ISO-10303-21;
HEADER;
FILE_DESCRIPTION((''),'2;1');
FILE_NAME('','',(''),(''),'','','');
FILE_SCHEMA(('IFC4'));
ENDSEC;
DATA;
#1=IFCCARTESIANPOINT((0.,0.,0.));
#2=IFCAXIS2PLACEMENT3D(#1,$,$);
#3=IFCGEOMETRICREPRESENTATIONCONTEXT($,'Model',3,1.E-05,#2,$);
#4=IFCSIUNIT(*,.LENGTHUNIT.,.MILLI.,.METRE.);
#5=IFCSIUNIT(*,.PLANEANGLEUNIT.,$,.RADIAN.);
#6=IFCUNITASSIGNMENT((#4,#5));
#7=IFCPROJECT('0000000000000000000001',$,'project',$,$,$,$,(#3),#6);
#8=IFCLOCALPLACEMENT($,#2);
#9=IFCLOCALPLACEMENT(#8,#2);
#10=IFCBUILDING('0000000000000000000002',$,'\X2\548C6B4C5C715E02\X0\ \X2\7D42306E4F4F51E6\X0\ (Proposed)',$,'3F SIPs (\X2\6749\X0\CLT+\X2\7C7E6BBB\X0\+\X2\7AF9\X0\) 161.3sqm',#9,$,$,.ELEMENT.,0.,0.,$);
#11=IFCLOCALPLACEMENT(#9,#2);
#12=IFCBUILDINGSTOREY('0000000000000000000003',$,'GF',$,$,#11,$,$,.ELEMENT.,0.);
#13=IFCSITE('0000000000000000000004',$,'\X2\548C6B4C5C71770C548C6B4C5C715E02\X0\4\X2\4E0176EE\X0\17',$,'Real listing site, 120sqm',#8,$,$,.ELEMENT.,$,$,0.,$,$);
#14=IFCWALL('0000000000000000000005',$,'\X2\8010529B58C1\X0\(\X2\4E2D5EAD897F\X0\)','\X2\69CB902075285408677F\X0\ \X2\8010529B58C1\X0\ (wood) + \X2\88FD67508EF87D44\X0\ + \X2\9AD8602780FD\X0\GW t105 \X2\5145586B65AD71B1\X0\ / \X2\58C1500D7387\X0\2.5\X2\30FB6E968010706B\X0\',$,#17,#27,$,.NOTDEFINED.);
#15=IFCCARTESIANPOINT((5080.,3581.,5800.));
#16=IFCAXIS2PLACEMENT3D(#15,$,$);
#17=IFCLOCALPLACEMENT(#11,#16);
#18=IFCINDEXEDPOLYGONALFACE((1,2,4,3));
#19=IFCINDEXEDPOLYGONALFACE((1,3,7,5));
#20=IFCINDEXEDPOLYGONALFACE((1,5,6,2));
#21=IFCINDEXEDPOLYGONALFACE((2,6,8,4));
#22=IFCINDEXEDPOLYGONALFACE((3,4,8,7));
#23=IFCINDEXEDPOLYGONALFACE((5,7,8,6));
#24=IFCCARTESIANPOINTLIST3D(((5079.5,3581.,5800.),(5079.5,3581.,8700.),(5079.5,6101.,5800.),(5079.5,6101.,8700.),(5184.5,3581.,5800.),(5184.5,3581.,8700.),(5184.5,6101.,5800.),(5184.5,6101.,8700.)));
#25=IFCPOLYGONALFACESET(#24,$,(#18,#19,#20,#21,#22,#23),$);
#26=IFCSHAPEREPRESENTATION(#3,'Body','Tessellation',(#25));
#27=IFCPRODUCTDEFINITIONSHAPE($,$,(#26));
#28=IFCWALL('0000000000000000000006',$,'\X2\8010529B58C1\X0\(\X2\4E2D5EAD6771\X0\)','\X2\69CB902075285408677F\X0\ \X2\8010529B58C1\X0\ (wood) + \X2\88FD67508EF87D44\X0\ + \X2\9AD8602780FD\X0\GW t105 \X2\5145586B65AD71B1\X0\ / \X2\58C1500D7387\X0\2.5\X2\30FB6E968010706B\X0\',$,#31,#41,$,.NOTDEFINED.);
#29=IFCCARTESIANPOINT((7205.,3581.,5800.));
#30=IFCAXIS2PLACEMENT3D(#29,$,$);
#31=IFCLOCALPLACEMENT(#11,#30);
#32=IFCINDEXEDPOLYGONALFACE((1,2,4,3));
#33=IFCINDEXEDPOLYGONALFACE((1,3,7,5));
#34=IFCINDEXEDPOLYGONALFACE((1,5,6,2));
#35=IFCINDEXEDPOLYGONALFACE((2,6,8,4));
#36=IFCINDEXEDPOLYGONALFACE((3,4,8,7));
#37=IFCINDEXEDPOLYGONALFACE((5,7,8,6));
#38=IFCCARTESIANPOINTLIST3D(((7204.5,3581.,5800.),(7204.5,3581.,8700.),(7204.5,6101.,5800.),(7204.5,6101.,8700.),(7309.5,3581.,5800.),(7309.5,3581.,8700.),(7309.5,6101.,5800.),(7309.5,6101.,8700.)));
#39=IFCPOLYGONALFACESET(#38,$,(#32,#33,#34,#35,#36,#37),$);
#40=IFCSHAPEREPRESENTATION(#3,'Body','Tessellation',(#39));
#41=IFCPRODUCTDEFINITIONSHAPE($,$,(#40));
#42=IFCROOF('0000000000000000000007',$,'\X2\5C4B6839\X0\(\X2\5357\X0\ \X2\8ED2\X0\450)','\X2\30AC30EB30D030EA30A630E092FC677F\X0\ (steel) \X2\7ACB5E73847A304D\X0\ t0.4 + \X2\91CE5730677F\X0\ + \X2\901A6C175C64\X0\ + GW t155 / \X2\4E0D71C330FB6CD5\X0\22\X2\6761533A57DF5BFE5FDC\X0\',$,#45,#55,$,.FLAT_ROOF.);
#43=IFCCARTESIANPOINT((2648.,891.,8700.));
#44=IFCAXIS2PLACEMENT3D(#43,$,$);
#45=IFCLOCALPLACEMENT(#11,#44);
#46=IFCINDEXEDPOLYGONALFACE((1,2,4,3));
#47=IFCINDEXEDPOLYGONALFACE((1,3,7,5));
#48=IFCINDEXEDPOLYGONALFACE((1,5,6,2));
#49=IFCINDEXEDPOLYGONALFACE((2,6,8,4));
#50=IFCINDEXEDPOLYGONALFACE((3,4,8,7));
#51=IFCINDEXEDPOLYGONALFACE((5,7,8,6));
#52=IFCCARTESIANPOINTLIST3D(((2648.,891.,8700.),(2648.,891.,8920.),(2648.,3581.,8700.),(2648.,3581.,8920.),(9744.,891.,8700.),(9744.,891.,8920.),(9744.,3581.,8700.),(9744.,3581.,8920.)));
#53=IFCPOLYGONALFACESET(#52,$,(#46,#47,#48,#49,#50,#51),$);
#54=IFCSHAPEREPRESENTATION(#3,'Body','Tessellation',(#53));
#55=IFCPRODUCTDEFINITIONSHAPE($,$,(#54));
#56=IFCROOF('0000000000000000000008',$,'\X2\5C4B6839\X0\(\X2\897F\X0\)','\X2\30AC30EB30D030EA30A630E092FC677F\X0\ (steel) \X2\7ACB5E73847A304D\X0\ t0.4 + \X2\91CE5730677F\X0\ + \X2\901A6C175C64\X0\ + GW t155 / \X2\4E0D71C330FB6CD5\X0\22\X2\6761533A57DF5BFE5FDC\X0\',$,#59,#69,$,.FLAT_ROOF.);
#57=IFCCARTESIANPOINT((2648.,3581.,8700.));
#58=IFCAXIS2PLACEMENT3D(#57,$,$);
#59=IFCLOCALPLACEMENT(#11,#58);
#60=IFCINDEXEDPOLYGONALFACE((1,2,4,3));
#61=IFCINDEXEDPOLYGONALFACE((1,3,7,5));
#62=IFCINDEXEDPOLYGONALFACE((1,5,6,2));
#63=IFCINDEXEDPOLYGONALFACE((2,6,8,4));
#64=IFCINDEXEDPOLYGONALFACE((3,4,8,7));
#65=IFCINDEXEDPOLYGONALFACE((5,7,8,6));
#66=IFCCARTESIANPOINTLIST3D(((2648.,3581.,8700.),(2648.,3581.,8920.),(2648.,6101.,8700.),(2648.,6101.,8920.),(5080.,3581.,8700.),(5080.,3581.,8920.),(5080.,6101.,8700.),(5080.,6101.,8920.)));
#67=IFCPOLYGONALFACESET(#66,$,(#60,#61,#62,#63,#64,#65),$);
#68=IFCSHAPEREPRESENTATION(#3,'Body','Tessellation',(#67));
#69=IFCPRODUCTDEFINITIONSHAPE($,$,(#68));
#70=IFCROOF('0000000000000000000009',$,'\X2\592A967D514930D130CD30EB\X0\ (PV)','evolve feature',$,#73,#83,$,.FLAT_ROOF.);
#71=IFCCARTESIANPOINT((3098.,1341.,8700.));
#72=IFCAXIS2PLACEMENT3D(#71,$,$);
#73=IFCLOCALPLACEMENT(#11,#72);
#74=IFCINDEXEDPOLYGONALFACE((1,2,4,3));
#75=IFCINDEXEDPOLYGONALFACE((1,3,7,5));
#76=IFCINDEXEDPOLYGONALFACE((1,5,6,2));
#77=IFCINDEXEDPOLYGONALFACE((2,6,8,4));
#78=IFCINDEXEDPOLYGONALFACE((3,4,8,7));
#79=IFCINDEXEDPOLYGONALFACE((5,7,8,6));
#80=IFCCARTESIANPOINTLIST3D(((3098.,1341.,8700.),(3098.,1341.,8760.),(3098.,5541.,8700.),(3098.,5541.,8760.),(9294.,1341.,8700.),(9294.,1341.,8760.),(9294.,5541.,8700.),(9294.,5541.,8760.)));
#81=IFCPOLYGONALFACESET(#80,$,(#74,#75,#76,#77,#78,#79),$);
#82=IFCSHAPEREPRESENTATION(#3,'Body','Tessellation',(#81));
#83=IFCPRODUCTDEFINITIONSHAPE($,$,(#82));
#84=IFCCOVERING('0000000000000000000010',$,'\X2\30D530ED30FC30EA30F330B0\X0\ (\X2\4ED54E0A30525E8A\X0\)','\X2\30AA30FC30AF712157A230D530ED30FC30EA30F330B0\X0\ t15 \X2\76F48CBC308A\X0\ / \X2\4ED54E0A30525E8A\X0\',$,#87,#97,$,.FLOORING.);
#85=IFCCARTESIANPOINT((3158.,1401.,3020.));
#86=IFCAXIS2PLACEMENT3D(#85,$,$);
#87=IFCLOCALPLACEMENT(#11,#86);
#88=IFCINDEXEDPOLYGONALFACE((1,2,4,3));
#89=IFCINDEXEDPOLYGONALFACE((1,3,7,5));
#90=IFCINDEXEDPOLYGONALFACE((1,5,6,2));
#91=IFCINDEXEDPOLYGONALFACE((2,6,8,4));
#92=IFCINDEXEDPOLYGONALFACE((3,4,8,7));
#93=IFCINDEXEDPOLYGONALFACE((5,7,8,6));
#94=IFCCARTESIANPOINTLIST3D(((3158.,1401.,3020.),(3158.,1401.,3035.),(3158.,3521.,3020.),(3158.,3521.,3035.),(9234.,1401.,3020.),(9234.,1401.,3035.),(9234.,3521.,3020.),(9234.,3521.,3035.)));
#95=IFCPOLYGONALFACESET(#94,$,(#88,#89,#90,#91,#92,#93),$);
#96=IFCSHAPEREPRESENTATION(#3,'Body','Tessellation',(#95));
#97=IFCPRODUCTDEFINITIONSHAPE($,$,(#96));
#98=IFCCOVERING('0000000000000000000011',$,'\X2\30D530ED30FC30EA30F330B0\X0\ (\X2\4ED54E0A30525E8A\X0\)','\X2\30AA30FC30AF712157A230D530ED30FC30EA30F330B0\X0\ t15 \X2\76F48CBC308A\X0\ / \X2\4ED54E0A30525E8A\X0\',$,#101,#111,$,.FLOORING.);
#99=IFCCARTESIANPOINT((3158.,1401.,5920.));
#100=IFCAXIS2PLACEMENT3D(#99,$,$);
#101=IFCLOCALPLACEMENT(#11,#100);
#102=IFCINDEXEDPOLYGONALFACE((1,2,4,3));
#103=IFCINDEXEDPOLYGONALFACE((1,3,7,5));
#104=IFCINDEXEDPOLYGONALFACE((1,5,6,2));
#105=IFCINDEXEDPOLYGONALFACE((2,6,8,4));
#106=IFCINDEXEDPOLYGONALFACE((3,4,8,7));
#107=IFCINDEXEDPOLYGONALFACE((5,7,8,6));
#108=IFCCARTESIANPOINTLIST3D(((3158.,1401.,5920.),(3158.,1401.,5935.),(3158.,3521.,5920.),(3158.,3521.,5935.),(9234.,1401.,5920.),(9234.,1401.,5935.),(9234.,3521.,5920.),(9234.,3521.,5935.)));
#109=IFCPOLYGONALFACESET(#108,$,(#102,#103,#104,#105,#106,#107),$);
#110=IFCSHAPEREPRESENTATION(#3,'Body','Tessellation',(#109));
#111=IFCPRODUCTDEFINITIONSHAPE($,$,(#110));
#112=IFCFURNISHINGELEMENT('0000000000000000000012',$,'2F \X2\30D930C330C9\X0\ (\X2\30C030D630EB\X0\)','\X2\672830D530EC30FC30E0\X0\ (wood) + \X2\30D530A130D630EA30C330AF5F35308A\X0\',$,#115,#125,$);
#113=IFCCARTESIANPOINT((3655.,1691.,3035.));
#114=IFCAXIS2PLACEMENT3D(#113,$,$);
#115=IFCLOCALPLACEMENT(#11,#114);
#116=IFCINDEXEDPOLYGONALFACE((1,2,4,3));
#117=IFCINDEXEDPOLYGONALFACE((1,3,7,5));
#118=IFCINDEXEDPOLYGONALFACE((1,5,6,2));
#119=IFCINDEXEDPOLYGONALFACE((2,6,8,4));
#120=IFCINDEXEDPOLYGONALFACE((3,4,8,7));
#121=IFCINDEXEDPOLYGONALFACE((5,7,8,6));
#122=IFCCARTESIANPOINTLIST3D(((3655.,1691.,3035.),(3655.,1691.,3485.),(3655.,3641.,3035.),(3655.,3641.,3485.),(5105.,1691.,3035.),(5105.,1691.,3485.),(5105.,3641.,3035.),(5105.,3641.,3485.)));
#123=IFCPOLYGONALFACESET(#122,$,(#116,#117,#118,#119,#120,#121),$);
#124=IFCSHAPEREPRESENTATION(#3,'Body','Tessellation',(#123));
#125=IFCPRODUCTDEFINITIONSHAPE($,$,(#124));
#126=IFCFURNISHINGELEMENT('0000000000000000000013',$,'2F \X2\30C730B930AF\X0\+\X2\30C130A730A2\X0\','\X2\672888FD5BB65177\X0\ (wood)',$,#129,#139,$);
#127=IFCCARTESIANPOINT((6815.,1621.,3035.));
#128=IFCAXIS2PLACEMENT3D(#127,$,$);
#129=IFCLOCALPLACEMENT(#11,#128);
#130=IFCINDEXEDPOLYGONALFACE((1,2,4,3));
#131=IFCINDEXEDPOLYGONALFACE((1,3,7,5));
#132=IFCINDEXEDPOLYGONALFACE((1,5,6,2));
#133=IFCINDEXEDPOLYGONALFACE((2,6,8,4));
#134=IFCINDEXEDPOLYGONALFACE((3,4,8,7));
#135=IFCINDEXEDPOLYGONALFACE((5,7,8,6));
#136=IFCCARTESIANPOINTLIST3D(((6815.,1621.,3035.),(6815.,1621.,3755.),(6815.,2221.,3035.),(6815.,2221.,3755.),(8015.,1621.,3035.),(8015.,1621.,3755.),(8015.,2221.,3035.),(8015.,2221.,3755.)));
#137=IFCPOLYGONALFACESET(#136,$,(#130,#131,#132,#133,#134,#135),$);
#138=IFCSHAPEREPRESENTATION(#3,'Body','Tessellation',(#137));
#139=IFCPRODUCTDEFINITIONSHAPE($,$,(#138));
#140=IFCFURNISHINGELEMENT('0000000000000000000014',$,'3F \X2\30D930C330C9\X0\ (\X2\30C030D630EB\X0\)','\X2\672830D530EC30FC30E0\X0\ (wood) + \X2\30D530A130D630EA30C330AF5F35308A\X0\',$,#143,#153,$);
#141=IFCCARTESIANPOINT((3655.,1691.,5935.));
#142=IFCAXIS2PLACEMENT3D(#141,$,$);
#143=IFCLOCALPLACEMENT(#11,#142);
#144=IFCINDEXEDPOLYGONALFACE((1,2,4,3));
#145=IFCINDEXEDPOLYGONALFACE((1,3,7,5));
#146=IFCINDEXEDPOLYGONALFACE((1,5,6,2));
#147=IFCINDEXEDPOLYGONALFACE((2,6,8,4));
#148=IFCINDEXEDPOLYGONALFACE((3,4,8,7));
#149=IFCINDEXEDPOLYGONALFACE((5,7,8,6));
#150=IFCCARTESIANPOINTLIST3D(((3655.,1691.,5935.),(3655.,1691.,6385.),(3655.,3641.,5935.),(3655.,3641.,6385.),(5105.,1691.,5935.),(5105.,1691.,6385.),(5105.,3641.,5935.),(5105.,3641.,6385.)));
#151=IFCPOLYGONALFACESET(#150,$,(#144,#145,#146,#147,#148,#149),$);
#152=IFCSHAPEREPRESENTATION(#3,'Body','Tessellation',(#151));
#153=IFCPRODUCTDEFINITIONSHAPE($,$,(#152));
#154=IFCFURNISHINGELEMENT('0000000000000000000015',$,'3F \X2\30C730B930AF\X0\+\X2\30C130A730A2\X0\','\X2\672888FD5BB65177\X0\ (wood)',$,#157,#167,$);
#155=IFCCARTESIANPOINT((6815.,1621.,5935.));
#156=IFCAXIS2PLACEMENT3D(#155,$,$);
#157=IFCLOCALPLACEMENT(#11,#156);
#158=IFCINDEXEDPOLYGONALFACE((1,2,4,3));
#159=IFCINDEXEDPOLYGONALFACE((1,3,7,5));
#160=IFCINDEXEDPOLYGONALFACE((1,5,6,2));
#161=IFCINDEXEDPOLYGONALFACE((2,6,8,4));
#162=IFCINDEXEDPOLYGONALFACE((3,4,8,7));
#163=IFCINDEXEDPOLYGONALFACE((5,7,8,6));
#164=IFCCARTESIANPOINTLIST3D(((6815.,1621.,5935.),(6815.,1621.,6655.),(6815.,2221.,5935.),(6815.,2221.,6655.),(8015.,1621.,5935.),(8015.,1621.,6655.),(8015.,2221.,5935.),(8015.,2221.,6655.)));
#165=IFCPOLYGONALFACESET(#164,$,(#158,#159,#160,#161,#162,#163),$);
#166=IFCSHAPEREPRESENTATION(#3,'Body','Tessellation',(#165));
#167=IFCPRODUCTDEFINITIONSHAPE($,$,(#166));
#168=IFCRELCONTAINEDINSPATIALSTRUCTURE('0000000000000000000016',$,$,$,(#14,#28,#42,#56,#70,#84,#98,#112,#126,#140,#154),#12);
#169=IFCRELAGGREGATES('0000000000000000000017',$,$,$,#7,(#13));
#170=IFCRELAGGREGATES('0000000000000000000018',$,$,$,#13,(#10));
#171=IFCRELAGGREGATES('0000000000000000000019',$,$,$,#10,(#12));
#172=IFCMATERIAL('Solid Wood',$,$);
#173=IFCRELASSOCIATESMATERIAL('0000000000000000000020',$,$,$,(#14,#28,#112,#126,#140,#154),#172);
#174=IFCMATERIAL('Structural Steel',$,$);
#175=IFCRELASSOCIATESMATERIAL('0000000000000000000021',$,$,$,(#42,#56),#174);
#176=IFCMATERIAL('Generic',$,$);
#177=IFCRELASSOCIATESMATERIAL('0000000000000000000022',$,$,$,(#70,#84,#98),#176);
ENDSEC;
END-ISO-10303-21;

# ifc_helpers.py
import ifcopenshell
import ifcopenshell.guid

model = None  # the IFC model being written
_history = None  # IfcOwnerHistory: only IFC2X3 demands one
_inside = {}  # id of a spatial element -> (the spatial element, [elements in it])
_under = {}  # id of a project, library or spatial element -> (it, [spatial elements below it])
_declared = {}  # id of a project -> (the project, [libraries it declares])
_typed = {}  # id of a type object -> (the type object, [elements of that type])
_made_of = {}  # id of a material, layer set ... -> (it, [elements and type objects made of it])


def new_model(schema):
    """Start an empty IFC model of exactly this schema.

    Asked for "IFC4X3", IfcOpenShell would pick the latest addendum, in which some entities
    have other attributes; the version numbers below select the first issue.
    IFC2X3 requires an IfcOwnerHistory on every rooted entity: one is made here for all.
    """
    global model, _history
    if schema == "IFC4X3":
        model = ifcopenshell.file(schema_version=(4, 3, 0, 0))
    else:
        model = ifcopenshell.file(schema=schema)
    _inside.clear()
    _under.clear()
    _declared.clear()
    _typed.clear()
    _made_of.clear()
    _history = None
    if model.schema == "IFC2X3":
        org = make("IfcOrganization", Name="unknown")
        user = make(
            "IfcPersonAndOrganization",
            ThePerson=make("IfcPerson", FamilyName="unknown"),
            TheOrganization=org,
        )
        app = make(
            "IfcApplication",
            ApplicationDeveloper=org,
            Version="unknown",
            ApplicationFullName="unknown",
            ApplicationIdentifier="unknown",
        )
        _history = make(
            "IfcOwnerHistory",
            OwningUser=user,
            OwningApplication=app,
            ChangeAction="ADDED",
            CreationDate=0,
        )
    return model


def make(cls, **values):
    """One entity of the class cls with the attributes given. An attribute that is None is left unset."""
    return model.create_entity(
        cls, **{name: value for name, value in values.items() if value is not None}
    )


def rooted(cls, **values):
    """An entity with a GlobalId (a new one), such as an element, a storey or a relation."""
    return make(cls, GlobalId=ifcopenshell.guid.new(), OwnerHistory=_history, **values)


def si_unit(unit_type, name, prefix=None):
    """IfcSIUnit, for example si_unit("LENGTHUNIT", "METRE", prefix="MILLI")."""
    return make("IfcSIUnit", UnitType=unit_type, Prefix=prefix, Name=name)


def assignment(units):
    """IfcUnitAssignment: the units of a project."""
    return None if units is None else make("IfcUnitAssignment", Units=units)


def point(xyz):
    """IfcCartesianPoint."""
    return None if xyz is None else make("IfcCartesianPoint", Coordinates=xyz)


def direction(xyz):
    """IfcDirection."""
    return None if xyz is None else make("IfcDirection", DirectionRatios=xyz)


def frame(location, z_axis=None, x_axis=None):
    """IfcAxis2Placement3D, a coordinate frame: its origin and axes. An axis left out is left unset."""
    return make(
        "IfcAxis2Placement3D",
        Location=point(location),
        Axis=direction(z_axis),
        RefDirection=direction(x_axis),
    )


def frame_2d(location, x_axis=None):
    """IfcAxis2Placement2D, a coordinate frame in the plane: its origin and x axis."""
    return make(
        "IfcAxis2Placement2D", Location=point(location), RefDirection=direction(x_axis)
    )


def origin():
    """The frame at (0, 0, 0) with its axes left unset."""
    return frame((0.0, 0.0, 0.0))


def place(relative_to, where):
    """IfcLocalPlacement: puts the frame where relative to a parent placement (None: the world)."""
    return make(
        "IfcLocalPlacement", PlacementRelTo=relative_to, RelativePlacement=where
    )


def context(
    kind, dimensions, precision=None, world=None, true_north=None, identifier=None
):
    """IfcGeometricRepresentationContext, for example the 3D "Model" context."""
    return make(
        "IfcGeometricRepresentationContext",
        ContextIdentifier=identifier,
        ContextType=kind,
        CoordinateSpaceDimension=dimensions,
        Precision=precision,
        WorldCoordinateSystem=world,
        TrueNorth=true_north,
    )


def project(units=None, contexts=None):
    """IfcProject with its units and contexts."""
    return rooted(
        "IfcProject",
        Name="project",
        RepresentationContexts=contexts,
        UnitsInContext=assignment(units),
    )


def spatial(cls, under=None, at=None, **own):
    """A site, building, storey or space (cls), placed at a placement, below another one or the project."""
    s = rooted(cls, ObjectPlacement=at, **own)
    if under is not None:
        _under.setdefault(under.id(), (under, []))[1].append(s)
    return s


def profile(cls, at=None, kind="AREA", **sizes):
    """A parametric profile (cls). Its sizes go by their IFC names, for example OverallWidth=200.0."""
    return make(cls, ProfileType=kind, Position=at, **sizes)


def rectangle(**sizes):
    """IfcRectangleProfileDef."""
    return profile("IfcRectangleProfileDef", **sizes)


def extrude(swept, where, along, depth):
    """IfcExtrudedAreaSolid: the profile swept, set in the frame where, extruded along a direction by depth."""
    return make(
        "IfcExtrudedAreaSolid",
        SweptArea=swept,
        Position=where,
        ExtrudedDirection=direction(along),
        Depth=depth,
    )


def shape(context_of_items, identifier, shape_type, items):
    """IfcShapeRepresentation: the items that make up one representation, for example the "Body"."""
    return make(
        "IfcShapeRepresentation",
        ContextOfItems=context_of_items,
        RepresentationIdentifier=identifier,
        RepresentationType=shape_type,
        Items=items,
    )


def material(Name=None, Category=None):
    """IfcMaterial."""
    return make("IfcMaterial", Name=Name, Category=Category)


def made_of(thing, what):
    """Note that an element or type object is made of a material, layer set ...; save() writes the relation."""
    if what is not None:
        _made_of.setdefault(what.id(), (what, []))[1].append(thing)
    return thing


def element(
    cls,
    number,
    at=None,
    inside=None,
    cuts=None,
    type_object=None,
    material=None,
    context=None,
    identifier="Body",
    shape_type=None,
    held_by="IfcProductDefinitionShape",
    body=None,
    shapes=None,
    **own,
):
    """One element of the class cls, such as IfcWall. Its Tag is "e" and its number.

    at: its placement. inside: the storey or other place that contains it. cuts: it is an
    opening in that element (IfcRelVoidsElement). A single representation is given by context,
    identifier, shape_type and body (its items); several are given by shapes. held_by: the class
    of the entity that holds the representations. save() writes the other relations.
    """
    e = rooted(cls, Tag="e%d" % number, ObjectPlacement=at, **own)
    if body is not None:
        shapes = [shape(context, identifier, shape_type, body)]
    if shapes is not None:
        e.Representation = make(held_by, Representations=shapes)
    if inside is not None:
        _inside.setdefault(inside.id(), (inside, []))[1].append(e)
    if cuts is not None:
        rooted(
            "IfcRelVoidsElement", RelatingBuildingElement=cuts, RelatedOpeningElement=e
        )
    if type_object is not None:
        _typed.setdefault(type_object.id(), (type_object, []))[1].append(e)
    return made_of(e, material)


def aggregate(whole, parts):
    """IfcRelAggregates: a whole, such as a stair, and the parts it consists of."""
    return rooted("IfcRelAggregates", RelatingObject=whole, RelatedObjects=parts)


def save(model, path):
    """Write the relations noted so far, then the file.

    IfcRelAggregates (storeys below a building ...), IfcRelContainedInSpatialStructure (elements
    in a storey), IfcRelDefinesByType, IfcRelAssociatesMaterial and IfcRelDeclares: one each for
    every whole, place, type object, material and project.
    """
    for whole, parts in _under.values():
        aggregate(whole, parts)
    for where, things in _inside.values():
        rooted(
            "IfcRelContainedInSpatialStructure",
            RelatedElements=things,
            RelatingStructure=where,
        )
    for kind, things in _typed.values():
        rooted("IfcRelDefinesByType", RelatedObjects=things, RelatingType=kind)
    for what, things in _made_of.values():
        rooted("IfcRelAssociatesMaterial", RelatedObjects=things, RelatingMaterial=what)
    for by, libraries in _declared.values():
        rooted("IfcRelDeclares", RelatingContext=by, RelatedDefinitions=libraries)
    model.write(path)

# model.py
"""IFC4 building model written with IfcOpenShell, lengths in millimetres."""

from ifc_helpers import new_model, si_unit, frame, frame_2d, origin, place, context, project, spatial, rectangle, extrude, material, element, save


model = new_model("IFC4")

# Units and contexts
model_context = context("Model", 3, precision=1e-05, world=origin())
ifc_project = project(units=[si_unit("LENGTHUNIT", "METRE", prefix="MILLI"), si_unit("PLANEANGLEUNIT", "RADIAN")], contexts=[model_context])

# Site, building, storey
site_placement = place(None, origin())
site = spatial("IfcSite", under=ifc_project, at=site_placement, Name="和歌山県和歌山市4丁目17", ObjectType="Real listing site, 120sqm", CompositionType="ELEMENT", RefElevation=0.0)
building_placement = place(site_placement, origin())
building = spatial("IfcBuilding", under=site, at=building_placement, Name="和歌山市 終の住処 (Proposed)", ObjectType="3F SIPs (杉CLT+籾殻+竹) 161.3sqm", CompositionType="ELEMENT", ElevationOfRefHeight=0.0, ElevationOfTerrain=0.0)
storey_placement = place(building_placement, origin())
storey = spatial("IfcBuildingStorey", under=building, at=storey_placement, Name="GF", CompositionType="ELEMENT", Elevation=0.0)

# Shared definitions
ifc_material_1 = material(Name="Solid Wood")

# Walls
wall_1_placement = place(storey_placement, frame((5080.0, 3581.0, 5800.0)))
element("IfcWall", 1, at=wall_1_placement, inside=storey, material=ifc_material_1, Name="耐力壁(中庭西)", Description="構造用合板 耐力壁 (wood) + 製材軸組 + 高性能GW t105 充填断熱 / 壁倍率2.5・準耐火", PredefinedType="NOTDEFINED", context=model_context, shape_type="SweptSolid", body=[
    extrude(rectangle(XDim=105.0, YDim=2520.0, at=frame_2d((52.0, 1260.0))), frame((5080.0, 3581.0, 5800.0)), (0.0, 0.0, 1.0), 2900.0),
])
wall_2_placement = place(storey_placement, frame((7205.0, 3581.0, 5800.0)))
element("IfcWall", 2, at=wall_2_placement, inside=storey, material=ifc_material_1, Name="耐力壁(中庭東)", Description="構造用合板 耐力壁 (wood) + 製材軸組 + 高性能GW t105 充填断熱 / 壁倍率2.5・準耐火", PredefinedType="NOTDEFINED", context=model_context, shape_type="SweptSolid", body=[
    extrude(rectangle(XDim=105.0, YDim=2520.0, at=frame_2d((52.0, 1260.0))), frame((7205.0, 3581.0, 5800.0)), (0.0, 0.0, 1.0), 2900.0),
])

# Roofs
ifc_material_2 = material(Name="Structural Steel")
roof_1_placement = place(storey_placement, frame((2648.0, 891.0, 8700.0)))
element("IfcRoof", 3, at=roof_1_placement, inside=storey, material=ifc_material_2, Name="屋根(南 軒450)", Description="ガルバリウム鋼板 (steel) 立平葺き t0.4 + 野地板 + 通気層 + GW t155 / 不燃・法22条区域対応", PredefinedType="FLAT_ROOF", context=model_context, shape_type="SweptSolid", body=[
    extrude(rectangle(XDim=7096.0, YDim=2690.0, at=frame_2d((3548.0, 1345.0))), frame((2648.0, 891.0, 8700.0)), (0.0, 0.0, 1.0), 220.0),
])
roof_2_placement = place(storey_placement, frame((2648.0, 3581.0, 8700.0)))
element("IfcRoof", 4, at=roof_2_placement, inside=storey, material=ifc_material_2, Name="屋根(西)", Description="ガルバリウム鋼板 (steel) 立平葺き t0.4 + 野地板 + 通気層 + GW t155 / 不燃・法22条区域対応", PredefinedType="FLAT_ROOF", context=model_context, shape_type="SweptSolid", body=[
    extrude(rectangle(XDim=2432.0, YDim=2520.0, at=frame_2d((1216.0, 1260.0))), frame((2648.0, 3581.0, 8700.0)), (0.0, 0.0, 1.0), 220.0),
])
ifc_material_3 = material(Name="Generic")
roof_3_placement = place(storey_placement, frame((3098.0, 1341.0, 8700.0)))
element("IfcRoof", 5, at=roof_3_placement, inside=storey, material=ifc_material_3, Name="太陽光パネル (PV)", Description="evolve feature", PredefinedType="FLAT_ROOF", context=model_context, shape_type="SweptSolid", body=[
    extrude(rectangle(XDim=6196.0, YDim=4200.0, at=frame_2d((3098.0, 2100.0))), frame((3098.0, 1341.0, 8700.0)), (0.0, 0.0, 1.0), 60.0),
])

# Coverings
covering_1_placement = place(storey_placement, frame((3158.0, 1401.0, 3020.0)))
element("IfcCovering", 6, at=covering_1_placement, inside=storey, material=ifc_material_3, Name="フローリング (仕上げ床)", Description="オーク無垢フローリング t15 直貼り / 仕上げ床", PredefinedType="FLOORING", context=model_context, shape_type="SweptSolid", body=[
    extrude(rectangle(XDim=6076.0, YDim=2120.0, at=frame_2d((3038.0, 1060.0))), frame((3158.0, 1401.0, 3020.0)), (0.0, 0.0, 1.0), 15.0),
])
covering_2_placement = place(storey_placement, frame((3158.0, 1401.0, 5920.0)))
element("IfcCovering", 7, at=covering_2_placement, inside=storey, material=ifc_material_3, Name="フローリング (仕上げ床)", Description="オーク無垢フローリング t15 直貼り / 仕上げ床", PredefinedType="FLOORING", context=model_context, shape_type="SweptSolid", body=[
    extrude(rectangle(XDim=6076.0, YDim=2120.0, at=frame_2d((3038.0, 1060.0))), frame((3158.0, 1401.0, 5920.0)), (0.0, 0.0, 1.0), 15.0),
])

# Furnishing elements
furnishing_1_placement = place(storey_placement, frame((3655.0, 1691.0, 3035.0)))
element("IfcFurnishingElement", 8, at=furnishing_1_placement, inside=storey, material=ifc_material_1, Name="2F ベッド (ダブル)", Description="木フレーム (wood) + ファブリック張り", context=model_context, shape_type="SweptSolid", body=[
    extrude(rectangle(XDim=1450.0, YDim=1950.0, at=frame_2d((725.0, 975.0))), frame((3655.0, 1691.0, 3035.0)), (0.0, 0.0, 1.0), 450.0),
])
furnishing_2_placement = place(storey_placement, frame((6815.0, 1621.0, 3035.0)))
element("IfcFurnishingElement", 9, at=furnishing_2_placement, inside=storey, material=ifc_material_1, Name="2F デスク+チェア", Description="木製家具 (wood)", context=model_context, shape_type="SweptSolid", body=[
    extrude(rectangle(XDim=1200.0, YDim=600.0, at=frame_2d((600.0, 300.0))), frame((6815.0, 1621.0, 3035.0)), (0.0, 0.0, 1.0), 720.0),
])
furnishing_3_placement = place(storey_placement, frame((3655.0, 1691.0, 5935.0)))
element("IfcFurnishingElement", 10, at=furnishing_3_placement, inside=storey, material=ifc_material_1, Name="3F ベッド (ダブル)", Description="木フレーム (wood) + ファブリック張り", context=model_context, shape_type="SweptSolid", body=[
    extrude(rectangle(XDim=1450.0, YDim=1950.0, at=frame_2d((725.0, 975.0))), frame((3655.0, 1691.0, 5935.0)), (0.0, 0.0, 1.0), 450.0),
])
furnishing_4_placement = place(storey_placement, frame((6815.0, 1621.0, 5935.0)))
element("IfcFurnishingElement", 11, at=furnishing_4_placement, inside=storey, material=ifc_material_1, Name="3F デスク+チェア", Description="木製家具 (wood)", context=model_context, shape_type="SweptSolid", body=[
    extrude(rectangle(XDim=1200.0, YDim=600.0, at=frame_2d((600.0, 300.0))), frame((6815.0, 1621.0, 5935.0)), (0.0, 0.0, 1.0), 720.0),
])

save(model, "model.ifc")
